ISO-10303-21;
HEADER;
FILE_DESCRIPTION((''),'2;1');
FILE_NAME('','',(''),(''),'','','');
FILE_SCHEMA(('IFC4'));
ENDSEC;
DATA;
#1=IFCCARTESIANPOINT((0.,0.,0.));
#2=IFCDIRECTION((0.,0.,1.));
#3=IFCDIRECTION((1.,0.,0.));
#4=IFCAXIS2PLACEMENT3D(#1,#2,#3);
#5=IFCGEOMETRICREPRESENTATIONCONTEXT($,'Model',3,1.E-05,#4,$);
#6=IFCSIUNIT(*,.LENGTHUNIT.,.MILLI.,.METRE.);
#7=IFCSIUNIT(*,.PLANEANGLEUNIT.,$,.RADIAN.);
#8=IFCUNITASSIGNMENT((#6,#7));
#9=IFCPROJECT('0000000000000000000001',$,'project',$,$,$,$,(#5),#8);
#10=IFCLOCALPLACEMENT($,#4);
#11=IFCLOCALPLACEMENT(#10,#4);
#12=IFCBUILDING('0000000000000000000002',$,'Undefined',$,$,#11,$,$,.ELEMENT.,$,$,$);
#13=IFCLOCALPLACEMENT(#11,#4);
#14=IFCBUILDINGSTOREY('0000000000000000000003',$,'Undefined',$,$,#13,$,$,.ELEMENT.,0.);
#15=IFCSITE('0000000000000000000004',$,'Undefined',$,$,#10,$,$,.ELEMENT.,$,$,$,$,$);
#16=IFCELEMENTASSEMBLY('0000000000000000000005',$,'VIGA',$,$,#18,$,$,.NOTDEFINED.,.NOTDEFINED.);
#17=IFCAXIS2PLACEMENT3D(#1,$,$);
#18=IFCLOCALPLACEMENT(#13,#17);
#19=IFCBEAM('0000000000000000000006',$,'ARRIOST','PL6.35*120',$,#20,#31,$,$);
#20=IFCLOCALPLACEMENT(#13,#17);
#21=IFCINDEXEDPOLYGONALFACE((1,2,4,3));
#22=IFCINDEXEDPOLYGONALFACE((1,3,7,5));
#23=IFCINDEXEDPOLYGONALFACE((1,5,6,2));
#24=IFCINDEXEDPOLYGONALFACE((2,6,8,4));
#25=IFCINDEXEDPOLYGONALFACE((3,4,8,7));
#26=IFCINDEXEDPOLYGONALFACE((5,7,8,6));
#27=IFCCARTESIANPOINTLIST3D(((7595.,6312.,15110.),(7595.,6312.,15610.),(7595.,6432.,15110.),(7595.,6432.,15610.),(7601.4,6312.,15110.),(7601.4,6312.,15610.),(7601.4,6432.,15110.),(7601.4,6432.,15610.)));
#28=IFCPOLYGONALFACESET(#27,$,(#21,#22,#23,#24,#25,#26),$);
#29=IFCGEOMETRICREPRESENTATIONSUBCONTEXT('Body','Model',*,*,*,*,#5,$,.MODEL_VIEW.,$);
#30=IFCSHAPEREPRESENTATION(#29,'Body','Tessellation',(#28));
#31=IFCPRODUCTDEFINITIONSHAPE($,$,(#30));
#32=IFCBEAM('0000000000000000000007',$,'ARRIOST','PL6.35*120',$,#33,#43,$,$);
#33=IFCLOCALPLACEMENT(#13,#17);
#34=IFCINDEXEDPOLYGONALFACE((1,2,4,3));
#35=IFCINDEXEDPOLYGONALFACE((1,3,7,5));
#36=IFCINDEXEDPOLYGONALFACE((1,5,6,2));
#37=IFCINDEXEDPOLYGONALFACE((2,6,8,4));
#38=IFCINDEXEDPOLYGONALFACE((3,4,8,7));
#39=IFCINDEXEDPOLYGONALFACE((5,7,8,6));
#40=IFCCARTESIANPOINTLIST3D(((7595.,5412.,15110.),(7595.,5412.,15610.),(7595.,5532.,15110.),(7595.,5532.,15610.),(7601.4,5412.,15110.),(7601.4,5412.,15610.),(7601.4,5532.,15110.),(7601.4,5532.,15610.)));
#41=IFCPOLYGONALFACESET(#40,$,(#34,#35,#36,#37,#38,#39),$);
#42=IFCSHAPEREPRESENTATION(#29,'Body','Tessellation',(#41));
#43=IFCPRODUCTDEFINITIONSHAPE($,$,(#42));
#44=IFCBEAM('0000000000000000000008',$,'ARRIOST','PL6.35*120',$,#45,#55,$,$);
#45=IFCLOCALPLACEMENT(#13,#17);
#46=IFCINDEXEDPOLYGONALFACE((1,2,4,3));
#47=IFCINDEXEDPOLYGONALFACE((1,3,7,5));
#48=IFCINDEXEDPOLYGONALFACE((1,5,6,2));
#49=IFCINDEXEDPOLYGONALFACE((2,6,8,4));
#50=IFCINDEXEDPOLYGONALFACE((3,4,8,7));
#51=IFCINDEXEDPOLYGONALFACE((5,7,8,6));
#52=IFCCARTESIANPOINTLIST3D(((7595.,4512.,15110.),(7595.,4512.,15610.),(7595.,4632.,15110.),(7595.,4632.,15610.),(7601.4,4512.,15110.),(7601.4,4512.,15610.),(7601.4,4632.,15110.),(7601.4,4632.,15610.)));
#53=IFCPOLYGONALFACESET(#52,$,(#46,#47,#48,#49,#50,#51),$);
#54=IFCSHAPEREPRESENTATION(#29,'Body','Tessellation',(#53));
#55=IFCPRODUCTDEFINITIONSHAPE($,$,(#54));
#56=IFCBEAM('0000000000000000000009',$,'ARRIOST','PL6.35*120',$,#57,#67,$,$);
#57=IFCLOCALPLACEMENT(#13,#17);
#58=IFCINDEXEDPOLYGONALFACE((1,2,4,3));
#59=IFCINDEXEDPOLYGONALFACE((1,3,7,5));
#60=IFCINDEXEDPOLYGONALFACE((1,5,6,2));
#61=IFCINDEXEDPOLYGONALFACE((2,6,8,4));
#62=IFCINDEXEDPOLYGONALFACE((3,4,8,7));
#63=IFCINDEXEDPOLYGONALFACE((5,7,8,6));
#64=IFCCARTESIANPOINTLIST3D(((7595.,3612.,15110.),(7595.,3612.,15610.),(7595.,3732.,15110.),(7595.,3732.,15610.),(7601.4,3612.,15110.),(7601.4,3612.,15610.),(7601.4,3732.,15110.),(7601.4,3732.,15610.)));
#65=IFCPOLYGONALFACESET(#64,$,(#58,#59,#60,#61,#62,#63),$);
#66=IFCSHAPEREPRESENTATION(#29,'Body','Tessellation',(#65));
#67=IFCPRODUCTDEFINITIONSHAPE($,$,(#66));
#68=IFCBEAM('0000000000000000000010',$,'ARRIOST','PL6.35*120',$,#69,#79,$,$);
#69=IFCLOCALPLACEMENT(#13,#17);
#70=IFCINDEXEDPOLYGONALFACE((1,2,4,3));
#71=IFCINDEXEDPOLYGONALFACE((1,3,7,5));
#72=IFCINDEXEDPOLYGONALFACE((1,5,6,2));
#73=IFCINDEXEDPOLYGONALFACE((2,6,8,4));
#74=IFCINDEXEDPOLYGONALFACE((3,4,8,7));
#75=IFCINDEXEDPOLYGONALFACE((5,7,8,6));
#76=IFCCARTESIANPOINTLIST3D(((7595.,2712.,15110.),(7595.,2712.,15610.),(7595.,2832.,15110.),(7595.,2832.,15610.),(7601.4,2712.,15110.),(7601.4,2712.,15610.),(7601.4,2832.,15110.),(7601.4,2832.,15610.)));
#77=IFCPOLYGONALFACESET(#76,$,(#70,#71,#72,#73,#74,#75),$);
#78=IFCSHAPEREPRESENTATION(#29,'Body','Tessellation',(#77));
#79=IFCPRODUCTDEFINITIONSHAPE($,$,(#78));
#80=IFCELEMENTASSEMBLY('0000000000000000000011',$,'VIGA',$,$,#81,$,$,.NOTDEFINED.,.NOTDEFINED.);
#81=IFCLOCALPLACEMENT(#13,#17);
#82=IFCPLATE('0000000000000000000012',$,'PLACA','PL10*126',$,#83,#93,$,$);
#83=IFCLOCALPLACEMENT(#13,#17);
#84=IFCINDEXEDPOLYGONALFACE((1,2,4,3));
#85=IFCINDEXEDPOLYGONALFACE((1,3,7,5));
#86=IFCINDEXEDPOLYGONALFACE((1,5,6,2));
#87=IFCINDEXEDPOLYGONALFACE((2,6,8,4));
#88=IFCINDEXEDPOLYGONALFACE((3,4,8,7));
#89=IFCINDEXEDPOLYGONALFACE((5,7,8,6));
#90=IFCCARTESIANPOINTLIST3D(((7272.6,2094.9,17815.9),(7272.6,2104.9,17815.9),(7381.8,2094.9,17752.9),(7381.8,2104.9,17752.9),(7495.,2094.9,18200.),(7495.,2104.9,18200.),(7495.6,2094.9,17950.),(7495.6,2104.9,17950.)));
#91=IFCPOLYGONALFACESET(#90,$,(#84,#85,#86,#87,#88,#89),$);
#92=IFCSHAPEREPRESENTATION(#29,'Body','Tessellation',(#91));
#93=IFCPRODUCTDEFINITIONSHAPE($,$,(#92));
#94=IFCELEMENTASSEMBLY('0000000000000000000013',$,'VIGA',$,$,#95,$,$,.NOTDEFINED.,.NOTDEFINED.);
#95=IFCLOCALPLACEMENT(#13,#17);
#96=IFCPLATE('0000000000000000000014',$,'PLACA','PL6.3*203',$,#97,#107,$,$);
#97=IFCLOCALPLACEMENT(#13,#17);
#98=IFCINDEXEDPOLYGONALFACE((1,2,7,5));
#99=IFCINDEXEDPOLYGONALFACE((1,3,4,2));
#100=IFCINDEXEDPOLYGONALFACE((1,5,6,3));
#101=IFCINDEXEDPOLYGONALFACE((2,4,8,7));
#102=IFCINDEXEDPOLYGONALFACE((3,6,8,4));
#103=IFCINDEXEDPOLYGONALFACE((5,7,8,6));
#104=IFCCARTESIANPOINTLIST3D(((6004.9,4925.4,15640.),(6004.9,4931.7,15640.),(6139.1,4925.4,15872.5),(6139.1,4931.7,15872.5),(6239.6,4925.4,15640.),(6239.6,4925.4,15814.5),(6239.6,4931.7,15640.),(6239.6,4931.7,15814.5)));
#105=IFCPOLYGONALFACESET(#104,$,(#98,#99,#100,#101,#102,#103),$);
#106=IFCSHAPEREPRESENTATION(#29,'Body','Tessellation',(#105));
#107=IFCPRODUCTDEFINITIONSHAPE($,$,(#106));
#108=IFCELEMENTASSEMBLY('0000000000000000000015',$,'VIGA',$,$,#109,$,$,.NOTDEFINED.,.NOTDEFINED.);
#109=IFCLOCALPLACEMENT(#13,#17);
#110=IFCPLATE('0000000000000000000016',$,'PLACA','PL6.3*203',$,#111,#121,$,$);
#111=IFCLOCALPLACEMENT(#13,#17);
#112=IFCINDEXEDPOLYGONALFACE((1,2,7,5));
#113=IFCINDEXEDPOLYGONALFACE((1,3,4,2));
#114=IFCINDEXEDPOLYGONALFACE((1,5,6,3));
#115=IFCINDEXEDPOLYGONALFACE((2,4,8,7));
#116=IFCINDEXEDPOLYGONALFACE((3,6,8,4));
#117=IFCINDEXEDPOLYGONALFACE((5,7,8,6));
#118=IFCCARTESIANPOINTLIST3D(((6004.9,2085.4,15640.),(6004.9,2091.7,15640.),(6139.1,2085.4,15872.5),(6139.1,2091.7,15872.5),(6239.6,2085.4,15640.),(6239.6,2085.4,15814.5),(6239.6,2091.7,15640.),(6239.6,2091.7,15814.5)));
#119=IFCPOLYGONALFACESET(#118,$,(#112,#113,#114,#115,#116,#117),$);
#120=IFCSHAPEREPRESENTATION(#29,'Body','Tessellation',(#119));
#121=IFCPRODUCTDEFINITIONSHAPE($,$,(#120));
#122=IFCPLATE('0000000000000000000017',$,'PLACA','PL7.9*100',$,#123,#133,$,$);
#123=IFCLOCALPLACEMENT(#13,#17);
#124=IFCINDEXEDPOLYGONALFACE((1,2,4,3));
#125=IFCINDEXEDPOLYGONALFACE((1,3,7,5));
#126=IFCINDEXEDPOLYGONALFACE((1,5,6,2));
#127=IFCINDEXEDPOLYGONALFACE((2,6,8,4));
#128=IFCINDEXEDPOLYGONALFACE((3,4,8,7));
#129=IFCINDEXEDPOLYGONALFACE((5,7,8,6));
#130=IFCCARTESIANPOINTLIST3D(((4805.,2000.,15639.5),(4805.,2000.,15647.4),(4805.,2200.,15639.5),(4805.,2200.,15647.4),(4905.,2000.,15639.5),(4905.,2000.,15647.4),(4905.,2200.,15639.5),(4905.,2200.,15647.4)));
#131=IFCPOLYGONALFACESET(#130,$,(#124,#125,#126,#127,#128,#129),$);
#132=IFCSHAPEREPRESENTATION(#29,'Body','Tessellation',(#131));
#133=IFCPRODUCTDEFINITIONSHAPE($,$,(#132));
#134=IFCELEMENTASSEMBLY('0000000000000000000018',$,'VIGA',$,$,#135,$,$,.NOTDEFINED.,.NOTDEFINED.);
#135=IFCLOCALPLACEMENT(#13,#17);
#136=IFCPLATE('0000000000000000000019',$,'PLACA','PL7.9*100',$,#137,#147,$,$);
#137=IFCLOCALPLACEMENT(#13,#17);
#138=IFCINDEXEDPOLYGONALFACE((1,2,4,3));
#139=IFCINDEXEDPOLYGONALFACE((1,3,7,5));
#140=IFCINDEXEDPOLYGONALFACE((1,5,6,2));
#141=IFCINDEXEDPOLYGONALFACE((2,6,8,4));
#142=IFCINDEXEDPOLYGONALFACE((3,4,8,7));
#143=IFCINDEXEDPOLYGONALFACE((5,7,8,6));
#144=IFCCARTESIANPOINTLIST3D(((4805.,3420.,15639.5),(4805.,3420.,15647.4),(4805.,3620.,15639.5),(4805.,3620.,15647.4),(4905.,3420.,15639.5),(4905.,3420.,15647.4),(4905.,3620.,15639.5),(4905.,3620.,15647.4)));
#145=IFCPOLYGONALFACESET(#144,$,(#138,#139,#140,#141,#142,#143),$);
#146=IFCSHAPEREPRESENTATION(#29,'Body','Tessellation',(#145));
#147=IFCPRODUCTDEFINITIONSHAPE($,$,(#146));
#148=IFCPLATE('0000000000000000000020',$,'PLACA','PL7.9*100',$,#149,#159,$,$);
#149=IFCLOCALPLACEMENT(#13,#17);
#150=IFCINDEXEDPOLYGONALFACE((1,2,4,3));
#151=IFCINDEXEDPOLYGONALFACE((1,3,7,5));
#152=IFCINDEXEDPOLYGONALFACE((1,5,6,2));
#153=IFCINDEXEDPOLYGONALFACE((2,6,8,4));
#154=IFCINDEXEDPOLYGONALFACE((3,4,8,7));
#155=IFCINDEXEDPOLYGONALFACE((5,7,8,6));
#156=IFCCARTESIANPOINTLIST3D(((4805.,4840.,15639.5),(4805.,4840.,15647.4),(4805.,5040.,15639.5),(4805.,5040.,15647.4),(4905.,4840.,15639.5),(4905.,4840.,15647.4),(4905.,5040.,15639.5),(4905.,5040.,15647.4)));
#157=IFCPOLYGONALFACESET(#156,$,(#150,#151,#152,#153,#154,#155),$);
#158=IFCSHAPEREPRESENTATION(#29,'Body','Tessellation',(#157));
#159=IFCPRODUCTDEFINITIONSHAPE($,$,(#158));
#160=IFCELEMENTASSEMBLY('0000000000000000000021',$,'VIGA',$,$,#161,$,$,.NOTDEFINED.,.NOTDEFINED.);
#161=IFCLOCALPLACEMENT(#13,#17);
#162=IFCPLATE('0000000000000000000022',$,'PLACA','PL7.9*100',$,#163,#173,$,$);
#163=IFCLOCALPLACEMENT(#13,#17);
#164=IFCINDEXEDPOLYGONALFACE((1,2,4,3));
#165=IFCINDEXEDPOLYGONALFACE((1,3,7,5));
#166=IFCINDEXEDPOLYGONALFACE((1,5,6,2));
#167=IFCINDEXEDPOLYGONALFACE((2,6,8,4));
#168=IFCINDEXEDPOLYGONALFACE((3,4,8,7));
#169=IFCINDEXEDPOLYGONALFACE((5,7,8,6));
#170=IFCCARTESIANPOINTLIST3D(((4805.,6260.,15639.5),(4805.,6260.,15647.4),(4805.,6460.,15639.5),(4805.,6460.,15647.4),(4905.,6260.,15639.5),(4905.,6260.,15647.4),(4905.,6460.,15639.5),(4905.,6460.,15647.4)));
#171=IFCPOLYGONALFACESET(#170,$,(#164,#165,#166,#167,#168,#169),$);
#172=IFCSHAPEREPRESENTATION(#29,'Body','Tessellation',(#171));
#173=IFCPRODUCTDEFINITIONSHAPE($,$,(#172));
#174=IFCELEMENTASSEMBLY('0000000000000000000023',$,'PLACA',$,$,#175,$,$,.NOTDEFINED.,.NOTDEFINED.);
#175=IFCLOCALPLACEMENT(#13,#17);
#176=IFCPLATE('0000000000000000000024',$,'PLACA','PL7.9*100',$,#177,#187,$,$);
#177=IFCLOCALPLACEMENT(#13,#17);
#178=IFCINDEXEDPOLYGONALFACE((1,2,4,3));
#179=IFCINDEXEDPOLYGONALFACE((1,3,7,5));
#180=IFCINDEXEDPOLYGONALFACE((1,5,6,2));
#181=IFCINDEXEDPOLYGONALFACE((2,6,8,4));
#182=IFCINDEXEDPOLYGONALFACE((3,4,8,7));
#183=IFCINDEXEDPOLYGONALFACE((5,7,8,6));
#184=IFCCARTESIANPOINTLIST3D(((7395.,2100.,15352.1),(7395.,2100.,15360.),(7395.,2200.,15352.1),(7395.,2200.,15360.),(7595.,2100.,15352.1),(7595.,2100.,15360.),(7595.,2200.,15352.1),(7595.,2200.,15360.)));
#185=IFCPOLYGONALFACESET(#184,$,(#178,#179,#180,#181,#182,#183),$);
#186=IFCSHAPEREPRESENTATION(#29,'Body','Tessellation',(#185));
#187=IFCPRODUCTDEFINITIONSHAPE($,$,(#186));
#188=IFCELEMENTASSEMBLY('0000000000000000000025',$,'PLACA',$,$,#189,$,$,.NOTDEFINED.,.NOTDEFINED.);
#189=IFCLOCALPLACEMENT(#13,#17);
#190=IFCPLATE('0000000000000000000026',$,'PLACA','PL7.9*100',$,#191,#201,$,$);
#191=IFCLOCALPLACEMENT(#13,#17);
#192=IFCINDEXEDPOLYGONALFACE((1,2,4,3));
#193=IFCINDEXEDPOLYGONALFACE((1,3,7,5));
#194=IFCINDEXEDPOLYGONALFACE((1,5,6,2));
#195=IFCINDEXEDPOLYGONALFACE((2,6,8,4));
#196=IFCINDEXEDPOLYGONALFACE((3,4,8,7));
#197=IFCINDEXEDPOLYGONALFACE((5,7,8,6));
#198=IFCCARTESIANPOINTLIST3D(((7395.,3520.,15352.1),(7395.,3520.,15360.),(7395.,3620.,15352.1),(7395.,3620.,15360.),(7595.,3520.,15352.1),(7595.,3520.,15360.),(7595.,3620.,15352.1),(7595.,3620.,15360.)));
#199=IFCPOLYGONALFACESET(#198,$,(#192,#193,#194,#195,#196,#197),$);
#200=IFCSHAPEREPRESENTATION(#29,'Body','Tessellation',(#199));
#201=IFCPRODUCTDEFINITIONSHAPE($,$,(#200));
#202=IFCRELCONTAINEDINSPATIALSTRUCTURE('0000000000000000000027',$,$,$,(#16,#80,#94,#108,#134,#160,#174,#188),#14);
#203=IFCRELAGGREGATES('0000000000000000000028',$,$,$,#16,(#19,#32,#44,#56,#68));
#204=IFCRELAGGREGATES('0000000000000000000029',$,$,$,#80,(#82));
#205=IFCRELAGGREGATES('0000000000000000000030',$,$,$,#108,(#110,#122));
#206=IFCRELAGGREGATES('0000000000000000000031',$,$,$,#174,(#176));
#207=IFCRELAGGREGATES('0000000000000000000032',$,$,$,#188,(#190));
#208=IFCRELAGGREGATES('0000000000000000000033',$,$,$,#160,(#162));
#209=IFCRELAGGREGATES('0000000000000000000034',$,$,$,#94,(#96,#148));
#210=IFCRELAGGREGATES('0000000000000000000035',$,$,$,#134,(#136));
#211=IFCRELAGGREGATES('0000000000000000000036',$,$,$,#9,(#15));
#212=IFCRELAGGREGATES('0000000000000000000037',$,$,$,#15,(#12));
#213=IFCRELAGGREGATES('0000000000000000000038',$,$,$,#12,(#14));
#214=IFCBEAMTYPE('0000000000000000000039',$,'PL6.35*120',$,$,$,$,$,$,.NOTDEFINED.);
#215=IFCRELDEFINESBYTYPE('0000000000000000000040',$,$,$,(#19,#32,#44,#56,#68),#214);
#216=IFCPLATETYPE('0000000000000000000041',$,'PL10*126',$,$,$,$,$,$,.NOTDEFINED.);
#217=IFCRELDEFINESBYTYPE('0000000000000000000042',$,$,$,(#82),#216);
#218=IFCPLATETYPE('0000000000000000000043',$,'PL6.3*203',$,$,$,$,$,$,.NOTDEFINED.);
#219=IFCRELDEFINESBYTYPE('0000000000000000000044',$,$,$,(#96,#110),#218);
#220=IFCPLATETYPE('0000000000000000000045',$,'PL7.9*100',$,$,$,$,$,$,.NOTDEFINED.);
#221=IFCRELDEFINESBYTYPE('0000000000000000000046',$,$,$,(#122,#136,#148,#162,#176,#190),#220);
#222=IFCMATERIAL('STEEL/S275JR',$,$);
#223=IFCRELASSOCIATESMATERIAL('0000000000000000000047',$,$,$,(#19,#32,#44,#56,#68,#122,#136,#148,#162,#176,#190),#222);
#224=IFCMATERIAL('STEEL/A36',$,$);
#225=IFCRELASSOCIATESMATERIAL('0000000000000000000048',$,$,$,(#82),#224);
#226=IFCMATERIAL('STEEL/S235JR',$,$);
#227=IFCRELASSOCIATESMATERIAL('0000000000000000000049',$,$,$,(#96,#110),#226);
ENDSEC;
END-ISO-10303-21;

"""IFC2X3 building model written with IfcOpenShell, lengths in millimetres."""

from ifc_helpers import new_model, si_unit, frame, origin_with_axes, origin_2d_with_axis, place, context, subcontext, project, spatial, polyline, rectangle, outline, extrude, material, type_object, element, aggregate, save


model = new_model("IFC2X3")

# Units and contexts
model_context = context("Model", 3, precision=1e-05, world=origin_with_axes())
body_context = subcontext(model_context, "Body", "Model", "MODEL_VIEW")
ifc_project = project(units=[si_unit("LENGTHUNIT", "METRE", prefix="MILLI"), si_unit("PLANEANGLEUNIT", "RADIAN")], contexts=[model_context])

# Site, building, storey
site_placement = place(None, origin_with_axes())
site = spatial("IfcSite", under=ifc_project, at=site_placement, Name="Undefined", CompositionType="ELEMENT")
building_placement = place(site_placement, origin_with_axes())
building = spatial("IfcBuilding", under=site, at=building_placement, Name="Undefined", CompositionType="ELEMENT")
storey_placement = place(building_placement, origin_with_axes())
storey = spatial("IfcBuildingStorey", under=building, at=storey_placement, Name="Undefined", CompositionType="ELEMENT", Elevation=0.0)

# Element assembly, beams
assembly_1_placement = place(storey_placement, origin_with_axes())
assembly_1 = element("IfcElementAssembly", 1, at=assembly_1_placement, inside=storey, Name="VIGA", AssemblyPlace="NOTDEFINED", PredefinedType="NOTDEFINED")
ifc_material_1 = material(Name="STEEL/S275JR")
beam_type = type_object("IfcBeamType", Name="PL6.35*120", PredefinedType="NOTDEFINED")
beam_1_placement = place(assembly_1_placement, frame((7598.2, 6372.0, 15110.0), z_axis=(0.0, 1.0, 0.0), x_axis=(0.0, 0.0, 1.0)))
beam_1 = element("IfcBeam", 2, at=beam_1_placement, type_object=beam_type, material=ifc_material_1, Name="ARRIOST", Description="PL6.35*120", context=body_context, shape_type="SweptSolid", body=[
    extrude(rectangle(XDim=6.3, YDim=120.0, at=origin_2d_with_axis()), frame((500.0, 0.0, 0.0), z_axis=(-1.0, 0.0, 0.0), x_axis=(0.0, -1.0, 0.0)), (0.0, 0.0, 1.0), 500.0),
])
beam_2_placement = place(assembly_1_placement, frame((7598.2, 5472.0, 15110.0), z_axis=(0.0, 1.0, 0.0), x_axis=(0.0, 0.0, 1.0)))
beam_2 = element("IfcBeam", 3, at=beam_2_placement, type_object=beam_type, material=ifc_material_1, Name="ARRIOST", Description="PL6.35*120", context=body_context, shape_type="SweptSolid", body=[
    extrude(rectangle(XDim=6.3, YDim=120.0, at=origin_2d_with_axis()), frame((500.0, 0.0, 0.0), z_axis=(-1.0, 0.0, 0.0), x_axis=(0.0, -1.0, 0.0)), (0.0, 0.0, 1.0), 500.0),
])
beam_3_placement = place(assembly_1_placement, frame((7598.2, 4572.0, 15110.0), z_axis=(0.0, 1.0, 0.0), x_axis=(0.0, 0.0, 1.0)))
beam_3 = element("IfcBeam", 4, at=beam_3_placement, type_object=beam_type, material=ifc_material_1, Name="ARRIOST", Description="PL6.35*120", context=body_context, shape_type="SweptSolid", body=[
    extrude(rectangle(XDim=6.3, YDim=120.0, at=origin_2d_with_axis()), frame((500.0, 0.0, 0.0), z_axis=(-1.0, 0.0, 0.0), x_axis=(0.0, -1.0, 0.0)), (0.0, 0.0, 1.0), 500.0),
])
beam_4_placement = place(assembly_1_placement, frame((7598.2, 3672.0, 15110.0), z_axis=(0.0, 1.0, 0.0), x_axis=(0.0, 0.0, 1.0)))
beam_4 = element("IfcBeam", 5, at=beam_4_placement, type_object=beam_type, material=ifc_material_1, Name="ARRIOST", Description="PL6.35*120", context=body_context, shape_type="SweptSolid", body=[
    extrude(rectangle(XDim=6.3, YDim=120.0, at=origin_2d_with_axis()), frame((500.0, 0.0, 0.0), z_axis=(-1.0, 0.0, 0.0), x_axis=(0.0, -1.0, 0.0)), (0.0, 0.0, 1.0), 500.0),
])
beam_5_placement = place(assembly_1_placement, frame((7598.2, 2772.0, 15110.0), z_axis=(0.0, 1.0, 0.0), x_axis=(0.0, 0.0, 1.0)))
beam_5 = element("IfcBeam", 6, at=beam_5_placement, type_object=beam_type, material=ifc_material_1, Name="ARRIOST", Description="PL6.35*120", context=body_context, shape_type="SweptSolid", body=[
    extrude(rectangle(XDim=6.3, YDim=120.0, at=origin_2d_with_axis()), frame((500.0, 0.0, 0.0), z_axis=(-1.0, 0.0, 0.0), x_axis=(0.0, -1.0, 0.0)), (0.0, 0.0, 1.0), 500.0),
])
aggregate(assembly_1, [beam_1, beam_2, beam_3, beam_4, beam_5])

# Element assemblies, plates
assembly_2_placement = place(storey_placement, origin_with_axes())
assembly_2 = element("IfcElementAssembly", 7, at=assembly_2_placement, inside=storey, Name="VIGA", AssemblyPlace="NOTDEFINED", PredefinedType="NOTDEFINED")
ifc_material_2 = material(Name="STEEL/A36")
plate_type_1 = type_object("IfcPlateType", Name="PL10*126", PredefinedType="NOTDEFINED")
plate_1_placement = place(assembly_2_placement, frame((7495.0, 2099.9, 18200.0), z_axis=(0.0, -1.0, 0.0), x_axis=(-0.500975, 0.0, -0.865462)))
plate_1 = element("IfcPlate", 8, at=plate_1_placement, type_object=plate_type_1, material=ifc_material_2, Name="PLACA", Description="PL10*126", context=body_context, shape_type="SweptSolid", body=[
    extrude(outline(polyline([(0.0, 0.0), (443.9, 0.0), (443.7, 126.0), (216.1, 125.7), (0.0, 0.0)])), frame((0.0, 0.0, -5.0), z_axis=(0.0, 0.0, 1.0), x_axis=(1.0, 0.0, 0.0)), (0.0, 0.0, 1.0), 10.0),
])
aggregate(assembly_2, [plate_1])
assembly_3_placement = place(storey_placement, origin_with_axes())
assembly_3 = element("IfcElementAssembly", 9, at=assembly_3_placement, inside=storey, Name="VIGA", AssemblyPlace="NOTDEFINED", PredefinedType="NOTDEFINED")
ifc_material_3 = material(Name="STEEL/S235JR")
plate_type_2 = type_object("IfcPlateType", Name="PL6.3*203", PredefinedType="NOTDEFINED")
plate_2_placement = place(assembly_3_placement, frame((6239.6, 4928.6, 15640.0), z_axis=(0.0, 1.0, 0.0), x_axis=(-1.0, 0.0, 0.0)))
plate_2 = element("IfcPlate", 10, at=plate_2_placement, type_object=plate_type_2, material=ifc_material_3, Name="PLACA", Description="PL6.3*203", context=body_context, shape_type="SweptSolid", body=[
    extrude(outline(polyline([(0.0, 0.0), (234.7, 0.0), (100.5, 232.5), (0.0, 174.5), (0.0, 0.0)])), frame((0.0, 0.0, -3.1), z_axis=(0.0, 0.0, 1.0), x_axis=(1.0, 0.0, 0.0)), (0.0, 0.0, 1.0), 6.3),
])

# Element assembly, plates
assembly_4_placement = place(storey_placement, origin_with_axes())
assembly_4 = element("IfcElementAssembly", 11, at=assembly_4_placement, inside=storey, Name="VIGA", AssemblyPlace="NOTDEFINED", PredefinedType="NOTDEFINED")
plate_3_placement = place(assembly_4_placement, frame((6239.6, 2088.6, 15640.0), z_axis=(0.0, 1.0, 0.0), x_axis=(-1.0, 0.0, 0.0)))
plate_3 = element("IfcPlate", 12, at=plate_3_placement, type_object=plate_type_2, material=ifc_material_3, Name="PLACA", Description="PL6.3*203", context=body_context, shape_type="SweptSolid", body=[
    extrude(outline(polyline([(0.0, 0.0), (234.7, 0.0), (100.5, 232.5), (0.0, 174.5), (0.0, 0.0)])), frame((0.0, 0.0, -3.1), z_axis=(0.0, 0.0, 1.0), x_axis=(1.0, 0.0, 0.0)), (0.0, 0.0, 1.0), 6.3),
])
plate_type_3 = type_object("IfcPlateType", Name="PL7.9*100", PredefinedType="NOTDEFINED")
plate_4_placement = place(assembly_4_placement, frame((4905.0, 2200.0, 15643.5), z_axis=(0.0, 0.0, 1.0), x_axis=(-1.0, 0.0, 0.0)))
plate_4 = element("IfcPlate", 13, at=plate_4_placement, type_object=plate_type_3, material=ifc_material_1, Name="PLACA", Description="PL7.9*100", context=body_context, shape_type="SweptSolid", body=[
    extrude(outline(polyline([(0.0, 0.0), (100.0, 0.0), (100.0, 200.0), (0.0, 200.0), (0.0, 0.0)])), frame((0.0, 0.0, -4.0), z_axis=(0.0, 0.0, 1.0), x_axis=(1.0, 0.0, 0.0)), (0.0, 0.0, 1.0), 7.9),
])
aggregate(assembly_4, [plate_3, plate_4])

# Element assembly, plate
assembly_5_placement = place(storey_placement, origin_with_axes())
assembly_5 = element("IfcElementAssembly", 14, at=assembly_5_placement, inside=storey, Name="VIGA", AssemblyPlace="NOTDEFINED", PredefinedType="NOTDEFINED")
plate_5_placement = place(assembly_5_placement, frame((4905.0, 3620.0, 15643.5), z_axis=(0.0, 0.0, 1.0), x_axis=(-1.0, 0.0, 0.0)))
plate_5 = element("IfcPlate", 15, at=plate_5_placement, type_object=plate_type_3, material=ifc_material_1, Name="PLACA", Description="PL7.9*100", context=body_context, shape_type="SweptSolid", body=[
    extrude(outline(polyline([(0.0, 0.0), (100.0, 0.0), (100.0, 200.0), (0.0, 200.0), (0.0, 0.0)])), frame((0.0, 0.0, -4.0), z_axis=(0.0, 0.0, 1.0), x_axis=(1.0, 0.0, 0.0)), (0.0, 0.0, 1.0), 7.9),
])

# Plate
plate_6_placement = place(assembly_3_placement, frame((4905.0, 5040.0, 15643.5), z_axis=(0.0, 0.0, 1.0), x_axis=(-1.0, 0.0, 0.0)))
plate_6 = element("IfcPlate", 16, at=plate_6_placement, type_object=plate_type_3, material=ifc_material_1, Name="PLACA", Description="PL7.9*100", context=body_context, shape_type="SweptSolid", body=[
    extrude(outline(polyline([(0.0, 0.0), (100.0, 0.0), (100.0, 200.0), (0.0, 200.0), (0.0, 0.0)])), frame((0.0, 0.0, -4.0), z_axis=(0.0, 0.0, 1.0), x_axis=(1.0, 0.0, 0.0)), (0.0, 0.0, 1.0), 7.9),
])

# Element assemblies, plates
assembly_6_placement = place(storey_placement, origin_with_axes())
assembly_6 = element("IfcElementAssembly", 17, at=assembly_6_placement, inside=storey, Name="VIGA", AssemblyPlace="NOTDEFINED", PredefinedType="NOTDEFINED")
plate_7_placement = place(assembly_6_placement, frame((4905.0, 6460.0, 15643.5), z_axis=(0.0, 0.0, 1.0), x_axis=(-1.0, 0.0, 0.0)))
plate_7 = element("IfcPlate", 18, at=plate_7_placement, type_object=plate_type_3, material=ifc_material_1, Name="PLACA", Description="PL7.9*100", context=body_context, shape_type="SweptSolid", body=[
    extrude(outline(polyline([(0.0, 0.0), (100.0, 0.0), (100.0, 200.0), (0.0, 200.0), (0.0, 0.0)])), frame((0.0, 0.0, -4.0), z_axis=(0.0, 0.0, 1.0), x_axis=(1.0, 0.0, 0.0)), (0.0, 0.0, 1.0), 7.9),
])
assembly_7_placement = place(storey_placement, origin_with_axes())
assembly_7 = element("IfcElementAssembly", 19, at=assembly_7_placement, inside=storey, Name="PLACA", AssemblyPlace="NOTDEFINED", PredefinedType="NOTDEFINED")
plate_8_placement = place(assembly_7_placement, frame((7395.0, 2200.0, 15356.0), z_axis=(0.0, 0.0, 1.0), x_axis=(0.0, -1.0, 0.0)))
plate_8 = element("IfcPlate", 20, at=plate_8_placement, type_object=plate_type_3, material=ifc_material_1, Name="PLACA", Description="PL7.9*100", context=body_context, shape_type="SweptSolid", body=[
    extrude(outline(polyline([(0.0, 0.0), (100.0, 0.0), (100.0, 200.0), (0.0, 200.0), (0.0, 0.0)])), frame((0.0, 0.0, -4.0), z_axis=(0.0, 0.0, 1.0), x_axis=(1.0, 0.0, 0.0)), (0.0, 0.0, 1.0), 7.9),
])
aggregate(assembly_7, [plate_8])
assembly_8_placement = place(storey_placement, origin_with_axes())
assembly_8 = element("IfcElementAssembly", 21, at=assembly_8_placement, inside=storey, Name="PLACA", AssemblyPlace="NOTDEFINED", PredefinedType="NOTDEFINED")
plate_9_placement = place(assembly_8_placement, frame((7395.0, 3620.0, 15356.0), z_axis=(0.0, 0.0, 1.0), x_axis=(0.0, -1.0, 0.0)))
plate_9 = element("IfcPlate", 22, at=plate_9_placement, type_object=plate_type_3, material=ifc_material_1, Name="PLACA", Description="PL7.9*100", context=body_context, shape_type="SweptSolid", body=[
    extrude(outline(polyline([(0.0, 0.0), (100.0, 0.0), (100.0, 200.0), (0.0, 200.0), (0.0, 0.0)])), frame((0.0, 0.0, -4.0), z_axis=(0.0, 0.0, 1.0), x_axis=(1.0, 0.0, 0.0)), (0.0, 0.0, 1.0), 7.9),
])
aggregate(assembly_8, [plate_9])

aggregate(assembly_6, [plate_7])
aggregate(assembly_3, [plate_2, plate_6])
aggregate(assembly_5, [plate_5])

save(model, "model.ifc")
